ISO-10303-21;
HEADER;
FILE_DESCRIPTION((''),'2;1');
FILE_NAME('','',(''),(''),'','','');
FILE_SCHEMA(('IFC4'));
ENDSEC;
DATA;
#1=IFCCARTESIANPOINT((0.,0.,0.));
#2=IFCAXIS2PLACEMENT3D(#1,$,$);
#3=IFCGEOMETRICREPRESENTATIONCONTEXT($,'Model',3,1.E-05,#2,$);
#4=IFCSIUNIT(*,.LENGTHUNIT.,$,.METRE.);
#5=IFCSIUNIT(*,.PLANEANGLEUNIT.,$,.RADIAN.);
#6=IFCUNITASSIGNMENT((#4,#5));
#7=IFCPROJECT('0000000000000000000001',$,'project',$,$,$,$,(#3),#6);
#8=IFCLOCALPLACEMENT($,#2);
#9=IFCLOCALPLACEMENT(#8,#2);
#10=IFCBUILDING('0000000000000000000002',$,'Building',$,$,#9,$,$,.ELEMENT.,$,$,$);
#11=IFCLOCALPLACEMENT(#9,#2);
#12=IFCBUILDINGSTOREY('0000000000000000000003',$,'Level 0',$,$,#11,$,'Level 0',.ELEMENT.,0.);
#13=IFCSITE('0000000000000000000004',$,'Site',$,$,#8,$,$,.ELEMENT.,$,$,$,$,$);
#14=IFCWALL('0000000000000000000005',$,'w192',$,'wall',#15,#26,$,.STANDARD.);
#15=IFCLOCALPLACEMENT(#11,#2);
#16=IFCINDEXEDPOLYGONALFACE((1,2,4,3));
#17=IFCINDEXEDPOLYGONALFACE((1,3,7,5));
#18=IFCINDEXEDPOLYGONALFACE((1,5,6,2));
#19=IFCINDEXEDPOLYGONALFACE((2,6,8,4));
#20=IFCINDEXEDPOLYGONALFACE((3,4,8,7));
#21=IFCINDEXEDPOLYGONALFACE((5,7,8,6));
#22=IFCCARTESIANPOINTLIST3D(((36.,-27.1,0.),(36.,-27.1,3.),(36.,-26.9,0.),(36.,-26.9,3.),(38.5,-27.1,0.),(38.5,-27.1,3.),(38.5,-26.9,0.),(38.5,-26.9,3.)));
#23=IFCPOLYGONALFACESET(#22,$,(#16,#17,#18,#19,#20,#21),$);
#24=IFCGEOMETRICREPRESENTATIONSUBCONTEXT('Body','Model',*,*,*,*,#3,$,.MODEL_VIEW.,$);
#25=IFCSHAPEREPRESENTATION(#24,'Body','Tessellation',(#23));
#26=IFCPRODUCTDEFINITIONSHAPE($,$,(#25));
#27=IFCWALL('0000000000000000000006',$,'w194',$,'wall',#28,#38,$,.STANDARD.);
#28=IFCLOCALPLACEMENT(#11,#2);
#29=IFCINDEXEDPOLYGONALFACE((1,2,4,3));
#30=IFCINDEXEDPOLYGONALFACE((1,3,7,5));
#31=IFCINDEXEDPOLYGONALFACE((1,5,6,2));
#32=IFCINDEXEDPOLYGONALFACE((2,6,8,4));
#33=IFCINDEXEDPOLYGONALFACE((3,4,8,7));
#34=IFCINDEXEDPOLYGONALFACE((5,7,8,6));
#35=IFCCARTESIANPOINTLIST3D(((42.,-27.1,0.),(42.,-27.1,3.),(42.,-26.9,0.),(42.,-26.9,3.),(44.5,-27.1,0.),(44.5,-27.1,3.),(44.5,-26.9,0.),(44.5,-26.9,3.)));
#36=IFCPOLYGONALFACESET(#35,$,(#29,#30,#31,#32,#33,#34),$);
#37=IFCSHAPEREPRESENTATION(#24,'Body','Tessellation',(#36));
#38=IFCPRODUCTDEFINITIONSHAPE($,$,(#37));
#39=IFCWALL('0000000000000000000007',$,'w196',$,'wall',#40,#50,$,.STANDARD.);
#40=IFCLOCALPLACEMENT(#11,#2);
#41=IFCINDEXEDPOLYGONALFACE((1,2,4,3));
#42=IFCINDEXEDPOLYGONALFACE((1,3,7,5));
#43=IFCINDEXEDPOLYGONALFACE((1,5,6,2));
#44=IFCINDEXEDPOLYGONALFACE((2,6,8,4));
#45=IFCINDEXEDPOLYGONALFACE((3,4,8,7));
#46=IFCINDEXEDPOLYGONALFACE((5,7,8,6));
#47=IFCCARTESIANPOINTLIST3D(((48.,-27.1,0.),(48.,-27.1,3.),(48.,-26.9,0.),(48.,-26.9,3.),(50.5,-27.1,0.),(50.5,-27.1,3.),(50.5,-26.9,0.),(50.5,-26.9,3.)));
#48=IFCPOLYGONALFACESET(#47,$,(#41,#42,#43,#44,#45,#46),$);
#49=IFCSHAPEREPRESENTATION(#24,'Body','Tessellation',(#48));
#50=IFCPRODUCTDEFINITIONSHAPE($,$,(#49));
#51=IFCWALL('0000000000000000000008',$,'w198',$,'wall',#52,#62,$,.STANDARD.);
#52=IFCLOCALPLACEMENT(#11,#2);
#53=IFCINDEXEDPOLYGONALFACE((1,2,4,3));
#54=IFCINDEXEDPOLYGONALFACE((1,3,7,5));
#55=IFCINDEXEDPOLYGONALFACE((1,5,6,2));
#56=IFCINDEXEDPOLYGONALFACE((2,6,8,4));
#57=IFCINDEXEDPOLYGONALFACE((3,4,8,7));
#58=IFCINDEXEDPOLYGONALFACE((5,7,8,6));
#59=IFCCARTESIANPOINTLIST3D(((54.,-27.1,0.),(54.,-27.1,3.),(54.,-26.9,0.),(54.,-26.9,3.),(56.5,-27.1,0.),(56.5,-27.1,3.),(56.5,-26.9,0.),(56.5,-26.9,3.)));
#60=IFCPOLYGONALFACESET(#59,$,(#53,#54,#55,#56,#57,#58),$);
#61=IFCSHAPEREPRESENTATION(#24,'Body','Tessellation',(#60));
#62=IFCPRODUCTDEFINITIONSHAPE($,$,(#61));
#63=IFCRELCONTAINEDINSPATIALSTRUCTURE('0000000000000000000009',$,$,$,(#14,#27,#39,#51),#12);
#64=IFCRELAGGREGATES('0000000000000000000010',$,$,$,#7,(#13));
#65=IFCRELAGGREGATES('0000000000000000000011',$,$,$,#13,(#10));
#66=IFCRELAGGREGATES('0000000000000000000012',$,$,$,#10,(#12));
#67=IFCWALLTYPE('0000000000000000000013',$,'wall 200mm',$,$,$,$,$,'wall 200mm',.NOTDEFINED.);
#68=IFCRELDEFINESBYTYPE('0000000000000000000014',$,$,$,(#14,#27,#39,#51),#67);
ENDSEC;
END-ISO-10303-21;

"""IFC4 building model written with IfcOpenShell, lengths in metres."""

from ifc_helpers import new_model, si_unit, frame, frame_2d, origin, place, context, subcontext, project, spatial, rectangle, extrude, type_object, element, save


model = new_model("IFC4")

# Units and contexts
model_context = context("Model", 3, precision=1e-05, world=origin())
body_context = subcontext(model_context, "Body", "Model", "MODEL_VIEW")
ifc_project = project(units=[si_unit("LENGTHUNIT", "METRE"), si_unit("PLANEANGLEUNIT", "RADIAN")], contexts=[model_context])

# Site, building, storey
site_placement = place(None, origin())
site = spatial("IfcSite", under=ifc_project, at=site_placement, Name="Site", CompositionType="ELEMENT")
building_placement = place(site_placement, origin())
building = spatial("IfcBuilding", under=site, at=building_placement, Name="Building", CompositionType="ELEMENT")
storey_placement = place(building_placement, origin())
storey = spatial("IfcBuildingStorey", under=building, at=storey_placement, Name="Level 0", LongName="Level 0", CompositionType="ELEMENT", Elevation=0.0)

# Walls
wall_type = type_object("IfcWallType", Name="wall 200mm", ElementType="wall 200mm", PredefinedType="NOTDEFINED")
for number, where, z_axis, x_axis, name in (
    (1, (36.0, -27.0, 0.0), (0.0, 0.0, 1.0), (1.0, 0.0, 0.0), "w192"),
    (2, (42.0, -27.0, 0.0), (0.0, 0.0, 1.0), (1.0, 0.0, 0.0), "w194"),
    (3, (48.0, -27.0, 0.0), (0.0, 0.0, 1.0), (1.0, 0.0, 0.0), "w196"),
    (4, (54.0, -27.0, 0.0), (0.0, 0.0, 1.0), (1.0, 0.0, 0.0), "w198"),
):
    element("IfcWall", number, at=place(storey_placement, frame(where, z_axis=z_axis, x_axis=x_axis)), inside=storey, type_object=wall_type, Name=name, ObjectType="wall", PredefinedType="STANDARD", context=body_context, shape_type="SweptSolid", body=[
        extrude(rectangle(XDim=2.5, YDim=0.2, at=frame_2d((1.25, 0.0))), origin(), (0.0, 0.0, 1.0), 3.0),
    ])

save(model, "model.ifc")
